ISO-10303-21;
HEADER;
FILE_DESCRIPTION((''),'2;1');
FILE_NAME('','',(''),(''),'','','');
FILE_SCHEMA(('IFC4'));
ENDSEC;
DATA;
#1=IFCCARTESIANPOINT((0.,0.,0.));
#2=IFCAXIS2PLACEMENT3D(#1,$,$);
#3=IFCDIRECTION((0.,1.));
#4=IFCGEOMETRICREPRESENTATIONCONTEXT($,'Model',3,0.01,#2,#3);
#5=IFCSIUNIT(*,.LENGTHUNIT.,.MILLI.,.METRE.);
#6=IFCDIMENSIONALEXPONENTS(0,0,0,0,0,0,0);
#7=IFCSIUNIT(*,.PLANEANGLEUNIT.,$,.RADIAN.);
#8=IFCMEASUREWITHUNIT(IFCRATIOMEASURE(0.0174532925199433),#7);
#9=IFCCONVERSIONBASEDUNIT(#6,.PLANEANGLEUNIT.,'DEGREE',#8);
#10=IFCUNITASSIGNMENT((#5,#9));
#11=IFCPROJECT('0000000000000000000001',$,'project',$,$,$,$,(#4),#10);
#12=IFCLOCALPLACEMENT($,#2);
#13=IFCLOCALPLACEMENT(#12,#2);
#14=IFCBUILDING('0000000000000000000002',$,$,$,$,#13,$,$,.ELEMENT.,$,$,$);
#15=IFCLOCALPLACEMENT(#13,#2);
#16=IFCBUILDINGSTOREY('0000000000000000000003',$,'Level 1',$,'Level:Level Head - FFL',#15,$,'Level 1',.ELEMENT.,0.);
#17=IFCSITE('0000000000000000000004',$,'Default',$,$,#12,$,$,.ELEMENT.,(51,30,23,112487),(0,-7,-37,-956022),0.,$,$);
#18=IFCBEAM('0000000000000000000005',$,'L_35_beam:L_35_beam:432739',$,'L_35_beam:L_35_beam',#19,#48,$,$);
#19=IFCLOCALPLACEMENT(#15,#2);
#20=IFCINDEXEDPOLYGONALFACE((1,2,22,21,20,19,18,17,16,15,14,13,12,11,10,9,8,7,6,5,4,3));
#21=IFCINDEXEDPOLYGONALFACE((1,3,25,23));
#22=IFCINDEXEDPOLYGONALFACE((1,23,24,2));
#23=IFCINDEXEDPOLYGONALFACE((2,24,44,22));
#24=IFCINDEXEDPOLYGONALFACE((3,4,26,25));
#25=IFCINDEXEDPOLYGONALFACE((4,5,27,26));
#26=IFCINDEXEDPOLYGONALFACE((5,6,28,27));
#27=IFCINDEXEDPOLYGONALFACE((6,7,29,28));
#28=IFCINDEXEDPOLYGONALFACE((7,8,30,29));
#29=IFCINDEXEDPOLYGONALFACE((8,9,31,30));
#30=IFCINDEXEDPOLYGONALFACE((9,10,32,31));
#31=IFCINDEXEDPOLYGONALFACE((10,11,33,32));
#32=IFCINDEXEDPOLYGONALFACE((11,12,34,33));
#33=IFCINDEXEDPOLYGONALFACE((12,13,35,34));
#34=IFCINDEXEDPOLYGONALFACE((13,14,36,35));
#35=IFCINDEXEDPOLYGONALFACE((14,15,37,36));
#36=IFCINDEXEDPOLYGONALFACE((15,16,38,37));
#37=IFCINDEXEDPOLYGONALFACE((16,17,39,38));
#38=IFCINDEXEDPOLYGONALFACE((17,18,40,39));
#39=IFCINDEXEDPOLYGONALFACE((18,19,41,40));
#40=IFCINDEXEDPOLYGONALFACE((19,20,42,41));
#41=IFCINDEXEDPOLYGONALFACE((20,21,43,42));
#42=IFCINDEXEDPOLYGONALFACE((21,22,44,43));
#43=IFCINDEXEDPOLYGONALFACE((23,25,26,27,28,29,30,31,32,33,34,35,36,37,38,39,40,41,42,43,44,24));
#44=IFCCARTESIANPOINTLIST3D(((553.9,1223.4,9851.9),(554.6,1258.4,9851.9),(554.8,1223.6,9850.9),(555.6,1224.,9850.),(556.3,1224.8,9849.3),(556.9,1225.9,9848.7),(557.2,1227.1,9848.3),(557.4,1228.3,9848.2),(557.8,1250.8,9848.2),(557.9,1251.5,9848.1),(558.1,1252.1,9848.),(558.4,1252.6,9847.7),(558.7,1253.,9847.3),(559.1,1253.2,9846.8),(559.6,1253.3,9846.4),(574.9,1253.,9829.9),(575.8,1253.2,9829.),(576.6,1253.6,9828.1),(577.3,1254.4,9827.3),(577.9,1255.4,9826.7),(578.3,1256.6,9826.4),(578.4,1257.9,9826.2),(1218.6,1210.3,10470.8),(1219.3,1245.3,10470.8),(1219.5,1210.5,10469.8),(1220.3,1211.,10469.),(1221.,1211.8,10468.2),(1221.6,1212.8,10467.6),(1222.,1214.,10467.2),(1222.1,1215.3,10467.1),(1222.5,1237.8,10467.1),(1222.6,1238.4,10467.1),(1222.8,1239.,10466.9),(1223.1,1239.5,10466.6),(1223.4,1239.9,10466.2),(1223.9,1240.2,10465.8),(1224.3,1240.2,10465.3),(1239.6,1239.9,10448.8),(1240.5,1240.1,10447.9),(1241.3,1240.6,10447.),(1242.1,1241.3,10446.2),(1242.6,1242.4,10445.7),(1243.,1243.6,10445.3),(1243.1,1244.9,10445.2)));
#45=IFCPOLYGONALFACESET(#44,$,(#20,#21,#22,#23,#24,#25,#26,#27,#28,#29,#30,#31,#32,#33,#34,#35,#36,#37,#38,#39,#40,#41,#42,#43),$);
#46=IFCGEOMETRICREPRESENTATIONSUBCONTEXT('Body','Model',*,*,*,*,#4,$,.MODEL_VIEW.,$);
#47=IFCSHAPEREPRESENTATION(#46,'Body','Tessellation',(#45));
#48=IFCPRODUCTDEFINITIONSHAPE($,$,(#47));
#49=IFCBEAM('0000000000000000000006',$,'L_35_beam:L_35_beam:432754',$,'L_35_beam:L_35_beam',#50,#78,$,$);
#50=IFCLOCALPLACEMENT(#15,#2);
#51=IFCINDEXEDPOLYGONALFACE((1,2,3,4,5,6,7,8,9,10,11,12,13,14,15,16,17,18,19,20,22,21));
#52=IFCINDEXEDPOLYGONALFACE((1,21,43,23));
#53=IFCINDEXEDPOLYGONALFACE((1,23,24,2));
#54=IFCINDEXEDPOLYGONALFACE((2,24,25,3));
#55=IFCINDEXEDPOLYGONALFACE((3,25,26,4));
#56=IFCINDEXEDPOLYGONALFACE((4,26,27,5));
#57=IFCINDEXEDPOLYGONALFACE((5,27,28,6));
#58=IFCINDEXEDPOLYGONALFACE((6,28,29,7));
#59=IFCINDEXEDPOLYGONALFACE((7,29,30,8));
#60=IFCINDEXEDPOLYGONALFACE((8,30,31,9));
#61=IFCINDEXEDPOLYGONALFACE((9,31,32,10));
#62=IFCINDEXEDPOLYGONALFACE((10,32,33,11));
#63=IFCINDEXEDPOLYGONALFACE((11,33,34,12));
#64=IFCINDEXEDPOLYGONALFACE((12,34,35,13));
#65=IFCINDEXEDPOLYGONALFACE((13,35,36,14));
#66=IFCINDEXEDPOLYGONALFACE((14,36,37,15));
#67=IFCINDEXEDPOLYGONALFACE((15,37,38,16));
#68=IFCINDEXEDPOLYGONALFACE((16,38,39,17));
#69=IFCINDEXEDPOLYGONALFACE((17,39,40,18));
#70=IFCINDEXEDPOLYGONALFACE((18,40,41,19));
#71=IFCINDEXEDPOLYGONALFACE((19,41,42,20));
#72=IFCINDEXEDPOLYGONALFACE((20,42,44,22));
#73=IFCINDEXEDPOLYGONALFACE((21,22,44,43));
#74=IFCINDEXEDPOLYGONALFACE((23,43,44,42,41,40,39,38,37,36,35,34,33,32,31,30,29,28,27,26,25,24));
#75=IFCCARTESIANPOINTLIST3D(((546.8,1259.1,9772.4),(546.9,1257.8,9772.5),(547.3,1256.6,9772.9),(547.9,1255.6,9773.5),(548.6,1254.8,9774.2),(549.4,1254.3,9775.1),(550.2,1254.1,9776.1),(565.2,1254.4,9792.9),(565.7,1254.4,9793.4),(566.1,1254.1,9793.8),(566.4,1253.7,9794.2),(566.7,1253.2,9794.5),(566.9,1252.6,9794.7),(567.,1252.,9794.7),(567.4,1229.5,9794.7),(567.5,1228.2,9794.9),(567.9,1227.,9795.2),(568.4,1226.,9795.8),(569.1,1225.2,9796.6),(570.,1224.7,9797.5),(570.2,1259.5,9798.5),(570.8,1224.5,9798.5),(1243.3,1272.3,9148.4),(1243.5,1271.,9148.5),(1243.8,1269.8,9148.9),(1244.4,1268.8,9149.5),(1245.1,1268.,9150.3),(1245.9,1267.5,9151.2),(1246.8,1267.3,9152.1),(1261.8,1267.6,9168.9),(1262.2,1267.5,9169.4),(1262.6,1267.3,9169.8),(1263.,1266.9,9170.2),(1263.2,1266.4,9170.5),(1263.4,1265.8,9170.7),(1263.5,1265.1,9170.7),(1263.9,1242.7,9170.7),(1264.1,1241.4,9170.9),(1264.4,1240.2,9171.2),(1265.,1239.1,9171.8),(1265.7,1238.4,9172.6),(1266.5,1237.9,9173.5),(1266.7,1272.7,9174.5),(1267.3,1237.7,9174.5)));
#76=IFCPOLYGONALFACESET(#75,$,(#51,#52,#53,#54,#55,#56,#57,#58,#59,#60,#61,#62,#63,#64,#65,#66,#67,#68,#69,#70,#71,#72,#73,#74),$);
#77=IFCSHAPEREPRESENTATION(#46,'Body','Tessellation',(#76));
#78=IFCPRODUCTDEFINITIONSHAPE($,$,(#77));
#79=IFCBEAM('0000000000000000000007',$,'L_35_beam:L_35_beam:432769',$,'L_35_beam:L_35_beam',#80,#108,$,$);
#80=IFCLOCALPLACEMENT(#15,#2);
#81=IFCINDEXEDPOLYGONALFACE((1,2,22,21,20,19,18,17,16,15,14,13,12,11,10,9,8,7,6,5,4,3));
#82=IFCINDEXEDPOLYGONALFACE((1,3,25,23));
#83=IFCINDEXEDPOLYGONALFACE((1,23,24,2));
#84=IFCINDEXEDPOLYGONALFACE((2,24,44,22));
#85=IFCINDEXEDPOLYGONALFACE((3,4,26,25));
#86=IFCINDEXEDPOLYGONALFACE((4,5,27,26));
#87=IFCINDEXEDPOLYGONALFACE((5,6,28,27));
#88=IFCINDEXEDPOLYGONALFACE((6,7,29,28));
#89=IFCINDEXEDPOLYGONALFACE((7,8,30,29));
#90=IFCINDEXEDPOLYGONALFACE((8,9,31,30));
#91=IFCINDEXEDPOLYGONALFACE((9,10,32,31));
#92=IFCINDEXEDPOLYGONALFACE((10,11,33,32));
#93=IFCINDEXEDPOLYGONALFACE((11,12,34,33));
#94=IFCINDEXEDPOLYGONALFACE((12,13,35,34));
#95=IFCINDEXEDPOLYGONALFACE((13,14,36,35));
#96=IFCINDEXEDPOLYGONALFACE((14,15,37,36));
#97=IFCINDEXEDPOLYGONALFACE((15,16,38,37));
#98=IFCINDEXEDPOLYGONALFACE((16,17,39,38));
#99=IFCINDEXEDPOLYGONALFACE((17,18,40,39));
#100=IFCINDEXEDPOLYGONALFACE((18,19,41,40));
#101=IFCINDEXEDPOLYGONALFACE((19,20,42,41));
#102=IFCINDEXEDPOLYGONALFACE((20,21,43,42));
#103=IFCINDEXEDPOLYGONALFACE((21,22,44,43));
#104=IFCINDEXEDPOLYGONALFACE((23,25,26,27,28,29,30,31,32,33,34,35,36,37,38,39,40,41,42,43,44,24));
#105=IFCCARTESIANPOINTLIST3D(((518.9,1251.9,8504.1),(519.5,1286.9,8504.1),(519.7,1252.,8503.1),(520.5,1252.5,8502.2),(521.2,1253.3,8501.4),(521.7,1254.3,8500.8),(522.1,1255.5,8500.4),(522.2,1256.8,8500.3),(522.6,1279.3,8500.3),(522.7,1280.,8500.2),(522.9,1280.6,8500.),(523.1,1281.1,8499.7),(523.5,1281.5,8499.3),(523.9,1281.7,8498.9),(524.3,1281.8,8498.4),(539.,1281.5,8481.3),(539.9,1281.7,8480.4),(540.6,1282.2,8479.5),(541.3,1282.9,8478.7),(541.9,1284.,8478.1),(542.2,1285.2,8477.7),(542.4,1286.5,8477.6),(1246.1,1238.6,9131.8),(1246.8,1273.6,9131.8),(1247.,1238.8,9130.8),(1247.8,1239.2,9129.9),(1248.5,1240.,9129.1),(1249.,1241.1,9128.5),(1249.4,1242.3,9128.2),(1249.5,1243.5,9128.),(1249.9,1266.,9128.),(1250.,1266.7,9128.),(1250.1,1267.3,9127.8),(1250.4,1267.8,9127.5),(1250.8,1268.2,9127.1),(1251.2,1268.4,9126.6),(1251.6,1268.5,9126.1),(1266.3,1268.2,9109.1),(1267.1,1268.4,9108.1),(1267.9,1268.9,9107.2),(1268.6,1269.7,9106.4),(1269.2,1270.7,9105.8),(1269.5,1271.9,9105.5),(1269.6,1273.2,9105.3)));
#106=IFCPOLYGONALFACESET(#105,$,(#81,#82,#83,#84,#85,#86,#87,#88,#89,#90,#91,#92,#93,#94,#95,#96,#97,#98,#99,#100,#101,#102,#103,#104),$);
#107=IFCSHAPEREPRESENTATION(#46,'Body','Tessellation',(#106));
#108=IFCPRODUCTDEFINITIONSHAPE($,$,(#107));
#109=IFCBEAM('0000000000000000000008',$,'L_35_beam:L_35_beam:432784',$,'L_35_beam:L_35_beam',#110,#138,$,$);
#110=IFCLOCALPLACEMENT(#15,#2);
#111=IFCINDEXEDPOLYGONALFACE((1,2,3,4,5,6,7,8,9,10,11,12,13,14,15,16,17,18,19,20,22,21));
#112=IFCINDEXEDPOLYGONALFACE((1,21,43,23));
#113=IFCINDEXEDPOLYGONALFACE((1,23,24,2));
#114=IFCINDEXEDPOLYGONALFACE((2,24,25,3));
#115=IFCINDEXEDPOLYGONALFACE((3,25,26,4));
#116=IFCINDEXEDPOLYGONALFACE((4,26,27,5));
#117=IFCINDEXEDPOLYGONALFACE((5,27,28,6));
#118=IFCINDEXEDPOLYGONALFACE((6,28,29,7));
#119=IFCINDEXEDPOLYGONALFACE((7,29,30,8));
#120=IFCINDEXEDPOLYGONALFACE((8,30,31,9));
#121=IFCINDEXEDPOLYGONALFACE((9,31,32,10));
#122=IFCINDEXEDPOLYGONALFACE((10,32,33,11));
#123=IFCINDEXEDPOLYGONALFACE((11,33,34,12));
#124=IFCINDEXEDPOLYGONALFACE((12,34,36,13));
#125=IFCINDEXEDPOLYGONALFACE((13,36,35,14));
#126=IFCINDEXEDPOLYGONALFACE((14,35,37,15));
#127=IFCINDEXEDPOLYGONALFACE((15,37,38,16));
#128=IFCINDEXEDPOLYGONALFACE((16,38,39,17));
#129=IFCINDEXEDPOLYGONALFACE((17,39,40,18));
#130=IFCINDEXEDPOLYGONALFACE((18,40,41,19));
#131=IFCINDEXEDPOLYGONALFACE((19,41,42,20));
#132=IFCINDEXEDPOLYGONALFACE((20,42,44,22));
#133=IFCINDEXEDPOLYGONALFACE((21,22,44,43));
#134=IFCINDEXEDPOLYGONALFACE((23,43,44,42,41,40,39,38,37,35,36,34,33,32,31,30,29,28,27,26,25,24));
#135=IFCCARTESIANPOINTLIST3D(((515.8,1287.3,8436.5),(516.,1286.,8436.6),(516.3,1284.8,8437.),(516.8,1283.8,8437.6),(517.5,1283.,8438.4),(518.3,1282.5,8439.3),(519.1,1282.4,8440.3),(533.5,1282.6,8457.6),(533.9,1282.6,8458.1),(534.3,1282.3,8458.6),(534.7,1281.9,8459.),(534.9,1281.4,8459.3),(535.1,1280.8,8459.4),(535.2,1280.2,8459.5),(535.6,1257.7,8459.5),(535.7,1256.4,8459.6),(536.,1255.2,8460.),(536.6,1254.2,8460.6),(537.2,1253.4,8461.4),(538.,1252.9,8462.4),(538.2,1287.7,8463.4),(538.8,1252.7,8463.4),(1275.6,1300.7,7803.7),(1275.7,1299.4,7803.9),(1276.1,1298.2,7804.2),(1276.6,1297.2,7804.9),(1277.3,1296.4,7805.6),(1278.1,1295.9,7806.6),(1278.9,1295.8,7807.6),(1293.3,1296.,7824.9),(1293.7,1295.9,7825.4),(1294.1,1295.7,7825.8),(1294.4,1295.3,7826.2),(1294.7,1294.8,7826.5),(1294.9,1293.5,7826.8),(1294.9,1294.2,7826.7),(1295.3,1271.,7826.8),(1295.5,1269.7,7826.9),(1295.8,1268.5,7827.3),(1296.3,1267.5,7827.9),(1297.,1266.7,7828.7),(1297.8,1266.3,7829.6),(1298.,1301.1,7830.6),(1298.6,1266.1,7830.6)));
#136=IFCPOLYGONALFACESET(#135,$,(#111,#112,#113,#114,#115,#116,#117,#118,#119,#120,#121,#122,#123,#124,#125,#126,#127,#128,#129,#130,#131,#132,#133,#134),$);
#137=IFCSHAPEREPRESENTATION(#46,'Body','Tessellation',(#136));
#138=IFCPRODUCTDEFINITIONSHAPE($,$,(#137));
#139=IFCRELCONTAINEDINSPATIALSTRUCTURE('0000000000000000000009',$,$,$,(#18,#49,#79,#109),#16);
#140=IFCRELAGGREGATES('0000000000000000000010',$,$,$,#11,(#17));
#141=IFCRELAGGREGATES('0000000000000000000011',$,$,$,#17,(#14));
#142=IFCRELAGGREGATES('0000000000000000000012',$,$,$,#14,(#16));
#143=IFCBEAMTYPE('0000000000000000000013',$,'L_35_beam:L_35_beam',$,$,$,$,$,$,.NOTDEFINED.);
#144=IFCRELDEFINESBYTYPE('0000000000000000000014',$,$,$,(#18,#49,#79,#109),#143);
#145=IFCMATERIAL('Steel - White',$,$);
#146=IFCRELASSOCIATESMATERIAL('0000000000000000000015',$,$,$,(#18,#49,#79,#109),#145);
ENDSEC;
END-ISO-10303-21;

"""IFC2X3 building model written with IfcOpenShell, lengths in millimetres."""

from ifc_helpers import new_model, entity, si_unit, converted_unit, direction, frame, frame_2d, origin, place, context, subcontext, project, spatial, polyline, circle_curve, parameter, trimmed, segment, composite_curve, outline, extrude, material, type_object, element, save


model = new_model("IFC2X3")

# Units and contexts
model_context = context("Model", 3, precision=0.01, world=origin(), true_north=direction((0.0, 1.0)))
body_context = subcontext(model_context, "Body", "Model", "MODEL_VIEW")
ifc_project = project(units=[si_unit("LENGTHUNIT", "METRE", prefix="MILLI"), converted_unit("PLANEANGLEUNIT", "DEGREE", entity("IfcRatioMeasure", 0.0174532925199433), si_unit("PLANEANGLEUNIT", "RADIAN"), dimensions=[0, 0, 0, 0, 0, 0, 0])], contexts=[model_context])

# Site, building, storey
site_placement = place(None, origin())
site = spatial("IfcSite", under=ifc_project, at=site_placement, Name="Default", CompositionType="ELEMENT", RefLatitude=(51, 30, 23, 112487), RefLongitude=(0, -7, -37, -956022), RefElevation=0.0)
building_placement = place(site_placement, origin())
building = spatial("IfcBuilding", under=site, at=building_placement, CompositionType="ELEMENT")
storey_placement = place(building_placement, origin())
storey = spatial("IfcBuildingStorey", under=building, at=storey_placement, Name="Level 1", ObjectType="Level:Level Head - FFL", LongName="Level 1", CompositionType="ELEMENT", Elevation=0.0)

# Beams
ifc_material_1 = material(Name="Steel - White")
beam_type_1 = type_object("IfcBeamType", Name="L_35_beam:L_35_beam", PredefinedType="NOTDEFINED")
beam_1_placement = place(storey_placement, frame((533.2, 1266.8, 9807.9), z_axis=(-0.681245, 0.013403, 0.731933), x_axis=(0.731791, -0.014397, 0.681377)))
element("IfcBeam", 1, at=beam_1_placement, inside=storey, type_object=beam_type_1, material=ifc_material_1, Name="L_35_beam:L_35_beam:432739", ObjectType="L_35_beam:L_35_beam", context=body_context, shape_type="SweptSolid", body=[
    extrude(outline(composite_curve([segment(polyline([(-23.2, -11.8), (11.8, -11.8)]), True, "CONTINUOUS"), segment(polyline([(11.8, -11.8), (11.8, 23.2)]), True, "CONTINUOUS"), segment(trimmed(circle_curve(frame_2d((11.8, 18.2), x_axis=(0.0, 1.0)), 5.0), [parameter(0.0)], [parameter(90.0)], True, "PARAMETER"), True, "CONTINUOUS"), segment(polyline([(6.8, 18.2), (6.8, -4.3)]), True, "CONTINUOUS"), segment(trimmed(circle_curve(frame_2d((4.3, -4.3), x_axis=(1.0, 0.0)), 2.5), [parameter(270.0)], [parameter(0.0)], True, "PARAMETER"), False, "CONTINUOUS"), segment(polyline([(4.3, -6.8), (-18.2, -6.8)]), True, "CONTINUOUS"), segment(trimmed(circle_curve(frame_2d((-18.2, -11.8), x_axis=(0.0, 1.0)), 5.0), [parameter(0.0)], [parameter(90.0)], True, "PARAMETER"), True, "CONTINUOUS")], self_intersect=False)), frame((45.7, -19.8, 5.7), z_axis=(1.0, 0.0, 0.0), x_axis=(0.0, 0.0, 1.0)), (0.0, 0.0, 1.0), 908.3),
])
beam_2_placement = place(storey_placement, frame((533.2, 1266.8, 9807.9), z_axis=(0.66707, 0.012627, 0.744888), x_axis=(0.744755, 0.014097, -0.667189)))
element("IfcBeam", 2, at=beam_2_placement, inside=storey, type_object=beam_type_1, material=ifc_material_1, Name="L_35_beam:L_35_beam:432754", ObjectType="L_35_beam:L_35_beam", context=body_context, shape_type="SweptSolid", body=[
    extrude(outline(composite_curve([segment(polyline([(-23.2, -11.8), (11.8, -11.8)]), True, "CONTINUOUS"), segment(polyline([(11.8, -11.8), (11.8, 23.2)]), True, "CONTINUOUS"), segment(trimmed(circle_curve(frame_2d((11.8, 18.2), x_axis=(0.0, 1.0)), 5.0), [parameter(0.0)], [parameter(90.0)], True, "PARAMETER"), True, "CONTINUOUS"), segment(polyline([(6.8, 18.2), (6.8, -4.3)]), True, "CONTINUOUS"), segment(trimmed(circle_curve(frame_2d((4.3, -4.3), x_axis=(1.0, 0.0)), 2.5), [parameter(270.0)], [parameter(0.0)], True, "PARAMETER"), False, "CONTINUOUS"), segment(polyline([(4.3, -6.8), (-18.2, -6.8)]), True, "CONTINUOUS"), segment(trimmed(circle_curve(frame_2d((-18.2, -11.8), x_axis=(0.0, 1.0)), 5.0), [parameter(0.0)], [parameter(90.0)], True, "PARAMETER"), True, "CONTINUOUS")], self_intersect=False)), frame((33.7, -19.8, 5.7), z_axis=(1.0, 0.0, 0.0), x_axis=(0.0, 0.0, 1.0)), (0.0, 0.0, 1.0), 935.2),
])
beam_3_placement = place(storey_placement, frame((504.9, 1295.1, 8468.2), z_axis=(-0.653245, 0.011914, 0.757053), x_axis=(0.756927, -0.013805, 0.653353)))
element("IfcBeam", 3, at=beam_3_placement, inside=storey, type_object=beam_type_1, material=ifc_material_1, Name="L_35_beam:L_35_beam:432769", ObjectType="L_35_beam:L_35_beam", context=body_context, shape_type="SweptSolid", body=[
    extrude(outline(composite_curve([segment(polyline([(-23.2, -11.8), (11.8, -11.8)]), True, "CONTINUOUS"), segment(polyline([(11.8, -11.8), (11.8, 23.2)]), True, "CONTINUOUS"), segment(trimmed(circle_curve(frame_2d((11.8, 18.2), x_axis=(0.0, 1.0)), 5.0), [parameter(0.0)], [parameter(90.0)], True, "PARAMETER"), True, "CONTINUOUS"), segment(polyline([(6.8, 18.2), (6.8, -4.3)]), True, "CONTINUOUS"), segment(trimmed(circle_curve(frame_2d((4.3, -4.3), x_axis=(1.0, 0.0)), 2.5), [parameter(270.0)], [parameter(0.0)], True, "PARAMETER"), False, "CONTINUOUS"), segment(polyline([(4.3, -6.8), (-18.2, -6.8)]), True, "CONTINUOUS"), segment(trimmed(circle_curve(frame_2d((-18.2, -11.8), x_axis=(0.0, 1.0)), 5.0), [parameter(0.0)], [parameter(90.0)], True, "PARAMETER"), True, "CONTINUOUS")], self_intersect=False)), frame((34.6, -19.8, 5.7), z_axis=(1.0, 0.0, 0.0), x_axis=(0.0, 0.0, 1.0)), (0.0, 0.0, 1.0), 960.8),
])
beam_4_placement = place(storey_placement, frame((504.9, 1295.1, 8468.2), z_axis=(0.639777, 0.011258, 0.768478), x_axis=(0.768359, 0.01352, -0.639876)))
element("IfcBeam", 4, at=beam_4_placement, inside=storey, type_object=beam_type_1, material=ifc_material_1, Name="L_35_beam:L_35_beam:432784", ObjectType="L_35_beam:L_35_beam", context=body_context, shape_type="SweptSolid", body=[
    extrude(outline(composite_curve([segment(polyline([(-23.2, -11.8), (11.8, -11.8)]), True, "CONTINUOUS"), segment(polyline([(11.8, -11.8), (11.8, 23.2)]), True, "CONTINUOUS"), segment(trimmed(circle_curve(frame_2d((11.8, 18.2), x_axis=(0.0, 1.0)), 5.0), [parameter(0.0)], [parameter(90.0)], True, "PARAMETER"), True, "CONTINUOUS"), segment(polyline([(6.8, 18.2), (6.8, -4.3)]), True, "CONTINUOUS"), segment(trimmed(circle_curve(frame_2d((4.3, -4.3), x_axis=(1.0, 0.0)), 2.5), [parameter(270.0)], [parameter(0.0)], True, "PARAMETER"), False, "CONTINUOUS"), segment(polyline([(4.3, -6.8), (-18.2, -6.8)]), True, "CONTINUOUS"), segment(trimmed(circle_curve(frame_2d((-18.2, -11.8), x_axis=(0.0, 1.0)), 5.0), [parameter(0.0)], [parameter(90.0)], True, "PARAMETER"), True, "CONTINUOUS")], self_intersect=False)), frame((28.6, -19.8, 5.7), z_axis=(1.0, 0.0, 0.0), x_axis=(0.0, 0.0, 1.0)), (0.0, 0.0, 1.0), 988.8),
])

save(model, "model.ifc")
